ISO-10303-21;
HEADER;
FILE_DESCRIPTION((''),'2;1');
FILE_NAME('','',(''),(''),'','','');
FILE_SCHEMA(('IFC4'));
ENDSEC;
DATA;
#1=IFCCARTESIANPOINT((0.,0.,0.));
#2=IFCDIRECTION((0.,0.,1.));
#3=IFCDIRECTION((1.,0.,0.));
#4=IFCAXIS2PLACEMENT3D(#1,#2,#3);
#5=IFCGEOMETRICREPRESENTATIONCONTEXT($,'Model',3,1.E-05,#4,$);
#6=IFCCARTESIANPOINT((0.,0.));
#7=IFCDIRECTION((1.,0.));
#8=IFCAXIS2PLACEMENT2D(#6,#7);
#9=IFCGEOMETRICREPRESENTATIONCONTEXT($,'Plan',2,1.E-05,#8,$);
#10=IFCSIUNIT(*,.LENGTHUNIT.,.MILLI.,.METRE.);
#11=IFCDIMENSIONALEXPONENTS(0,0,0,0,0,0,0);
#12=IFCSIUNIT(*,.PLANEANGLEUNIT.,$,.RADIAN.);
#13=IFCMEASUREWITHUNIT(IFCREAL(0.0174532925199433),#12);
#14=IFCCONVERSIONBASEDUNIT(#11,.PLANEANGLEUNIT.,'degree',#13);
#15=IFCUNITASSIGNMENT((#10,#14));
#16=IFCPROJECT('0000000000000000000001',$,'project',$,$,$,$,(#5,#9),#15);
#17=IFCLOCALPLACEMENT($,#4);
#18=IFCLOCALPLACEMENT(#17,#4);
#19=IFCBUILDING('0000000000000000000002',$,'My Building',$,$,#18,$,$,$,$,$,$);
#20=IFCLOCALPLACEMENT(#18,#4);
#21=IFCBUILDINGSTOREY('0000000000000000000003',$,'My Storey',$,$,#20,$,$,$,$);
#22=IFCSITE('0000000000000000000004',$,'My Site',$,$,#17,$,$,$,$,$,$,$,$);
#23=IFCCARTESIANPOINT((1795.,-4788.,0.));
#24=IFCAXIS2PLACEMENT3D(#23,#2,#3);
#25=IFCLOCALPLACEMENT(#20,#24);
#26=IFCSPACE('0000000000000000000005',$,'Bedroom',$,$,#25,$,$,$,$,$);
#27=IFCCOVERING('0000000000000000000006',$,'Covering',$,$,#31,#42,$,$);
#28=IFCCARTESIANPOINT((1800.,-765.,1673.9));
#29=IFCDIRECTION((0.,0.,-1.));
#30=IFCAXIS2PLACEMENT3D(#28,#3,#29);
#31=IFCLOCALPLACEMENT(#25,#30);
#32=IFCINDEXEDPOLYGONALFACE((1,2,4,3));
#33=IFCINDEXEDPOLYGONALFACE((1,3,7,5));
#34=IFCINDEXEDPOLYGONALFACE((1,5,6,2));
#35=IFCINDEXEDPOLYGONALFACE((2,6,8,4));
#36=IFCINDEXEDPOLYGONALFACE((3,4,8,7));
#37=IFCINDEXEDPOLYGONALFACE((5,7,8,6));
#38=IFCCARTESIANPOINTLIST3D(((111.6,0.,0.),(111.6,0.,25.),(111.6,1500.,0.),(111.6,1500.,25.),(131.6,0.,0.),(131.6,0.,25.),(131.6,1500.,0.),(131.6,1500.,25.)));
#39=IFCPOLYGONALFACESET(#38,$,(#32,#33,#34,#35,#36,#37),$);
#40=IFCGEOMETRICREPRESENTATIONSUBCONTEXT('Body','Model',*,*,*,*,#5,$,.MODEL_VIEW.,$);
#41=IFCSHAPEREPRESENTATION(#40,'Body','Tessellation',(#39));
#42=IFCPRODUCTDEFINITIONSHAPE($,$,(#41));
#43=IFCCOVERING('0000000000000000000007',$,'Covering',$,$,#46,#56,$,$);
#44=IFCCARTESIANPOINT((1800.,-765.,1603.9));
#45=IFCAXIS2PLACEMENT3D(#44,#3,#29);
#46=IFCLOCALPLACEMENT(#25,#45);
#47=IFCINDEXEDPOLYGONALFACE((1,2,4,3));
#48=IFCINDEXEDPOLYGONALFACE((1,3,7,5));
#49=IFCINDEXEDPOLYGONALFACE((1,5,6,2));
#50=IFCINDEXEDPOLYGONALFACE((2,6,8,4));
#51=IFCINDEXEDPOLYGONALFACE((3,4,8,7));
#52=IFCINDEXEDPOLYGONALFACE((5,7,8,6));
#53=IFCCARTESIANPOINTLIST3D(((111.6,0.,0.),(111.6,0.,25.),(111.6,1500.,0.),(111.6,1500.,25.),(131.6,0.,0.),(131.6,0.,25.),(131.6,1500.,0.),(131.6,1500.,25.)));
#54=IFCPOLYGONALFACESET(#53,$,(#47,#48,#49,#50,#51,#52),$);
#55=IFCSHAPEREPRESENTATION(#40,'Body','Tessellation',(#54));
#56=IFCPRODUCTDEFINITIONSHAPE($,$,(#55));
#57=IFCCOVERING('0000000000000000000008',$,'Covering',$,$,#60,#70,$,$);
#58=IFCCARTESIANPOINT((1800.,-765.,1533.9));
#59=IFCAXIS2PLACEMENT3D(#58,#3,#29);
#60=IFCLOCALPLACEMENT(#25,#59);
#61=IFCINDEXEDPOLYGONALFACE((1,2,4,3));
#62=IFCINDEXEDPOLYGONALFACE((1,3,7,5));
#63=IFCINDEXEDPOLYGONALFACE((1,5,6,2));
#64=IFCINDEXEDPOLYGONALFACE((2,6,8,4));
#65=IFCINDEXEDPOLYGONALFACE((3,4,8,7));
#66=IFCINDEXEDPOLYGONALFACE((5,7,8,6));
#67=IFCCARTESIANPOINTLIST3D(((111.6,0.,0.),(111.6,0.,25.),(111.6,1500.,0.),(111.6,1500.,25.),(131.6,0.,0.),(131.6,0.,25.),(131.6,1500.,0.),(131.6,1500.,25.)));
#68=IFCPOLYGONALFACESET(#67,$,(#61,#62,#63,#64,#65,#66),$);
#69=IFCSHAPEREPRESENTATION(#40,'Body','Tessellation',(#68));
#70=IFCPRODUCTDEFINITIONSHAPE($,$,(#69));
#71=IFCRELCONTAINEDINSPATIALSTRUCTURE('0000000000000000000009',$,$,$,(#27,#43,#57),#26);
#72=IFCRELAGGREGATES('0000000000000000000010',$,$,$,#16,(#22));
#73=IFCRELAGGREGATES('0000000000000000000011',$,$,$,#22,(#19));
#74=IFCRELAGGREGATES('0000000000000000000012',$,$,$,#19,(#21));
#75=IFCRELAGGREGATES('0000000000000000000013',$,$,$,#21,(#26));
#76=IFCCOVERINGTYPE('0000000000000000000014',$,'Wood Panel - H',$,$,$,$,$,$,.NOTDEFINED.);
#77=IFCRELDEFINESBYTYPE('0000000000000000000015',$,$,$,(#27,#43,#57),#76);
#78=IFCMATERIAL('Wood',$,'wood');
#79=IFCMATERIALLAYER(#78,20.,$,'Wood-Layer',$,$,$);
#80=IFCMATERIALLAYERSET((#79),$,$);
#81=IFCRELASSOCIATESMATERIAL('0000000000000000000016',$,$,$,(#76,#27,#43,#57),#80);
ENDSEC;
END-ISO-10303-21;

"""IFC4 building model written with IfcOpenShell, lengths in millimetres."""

from ifc_helpers import new_model, entity, si_unit, converted_unit, frame, origin_with_axes, origin_2d_with_axis, place, context, subcontext, project, spatial, line, indexed_curve, outline, extrude, material, layer, layer_set, layer_usage, type_object, element, save


model = new_model("IFC4")

# Units and contexts
model_context = context("Model", 3, precision=1e-05, world=origin_with_axes())
plan_context = context("Plan", 2, precision=1e-05, world=origin_2d_with_axis())
body_context_1 = subcontext(model_context, "Body", "Model", "MODEL_VIEW")
ifc_project = project(units=[si_unit("LENGTHUNIT", "METRE", prefix="MILLI"), converted_unit("PLANEANGLEUNIT", "degree", entity("IfcReal", 0.0174532925199433), si_unit("PLANEANGLEUNIT", "RADIAN"), dimensions=[0, 0, 0, 0, 0, 0, 0])], contexts=[model_context, plan_context])

# Site, building, storey
site_placement = place(None, origin_with_axes())
site = spatial("IfcSite", under=ifc_project, at=site_placement, Name="My Site")
building_placement = place(site_placement, origin_with_axes())
building = spatial("IfcBuilding", under=site, at=building_placement, Name="My Building")
storey_placement = place(building_placement, origin_with_axes())
storey = spatial("IfcBuildingStorey", under=building, at=storey_placement, Name="My Storey")

# Shared definitions
space_placement = place(storey_placement, frame((1795.0, -4788.0, 0.0), z_axis=(0.0, 0.0, 1.0), x_axis=(1.0, 0.0, 0.0)))
space = spatial("IfcSpace", under=storey, at=space_placement, Name="Bedroom")

# Coverings
ifc_material_1 = material(Name="Wood", Category="wood")
ifc_layer_1 = layer(ifc_material_1, 20.0, Name="Wood-Layer")
ifc_layer_set_1 = layer_set([ifc_layer_1])
covering_type_1 = type_object("IfcCoveringType", Name="Wood Panel - H", PredefinedType="NOTDEFINED", material=ifc_layer_set_1)
ifc_layer_usage_1 = layer_usage(ifc_layer_set_1, "AXIS3", "POSITIVE", 0.0)
covering_1_placement = place(space_placement, frame((1800.0, -765.0, 1673.9), z_axis=(1.0, 0.0, 0.0), x_axis=(0.0, 0.0, -1.0)))
element("IfcCovering", 1, at=covering_1_placement, inside=space, type_object=covering_type_1, material=ifc_layer_usage_1, Name="Covering", context=body_context_1, shape_type="SweptSolid", body=[
    extrude(outline(indexed_curve([(131.6, 1500.0), (111.6, 1500.0), (111.6, 0.0), (131.6, 0.0)], segments=[line(3, 2), line(2, 1), line(1, 4), line(4, 3)], self_intersect=False)), None, (0.0, 0.0, 1.0), 25.0),
])
ifc_layer_usage_2 = layer_usage(ifc_layer_set_1, "AXIS3", "POSITIVE", 0.0)
covering_2_placement = place(space_placement, frame((1800.0, -765.0, 1603.9), z_axis=(1.0, 0.0, 0.0), x_axis=(0.0, 0.0, -1.0)))
element("IfcCovering", 2, at=covering_2_placement, inside=space, type_object=covering_type_1, material=ifc_layer_usage_2, Name="Covering", context=body_context_1, shape_type="SweptSolid", body=[
    extrude(outline(indexed_curve([(131.6, 1500.0), (111.6, 1500.0), (111.6, 0.0), (131.6, 0.0)], segments=[line(3, 2), line(2, 1), line(1, 4), line(4, 3)], self_intersect=False)), None, (0.0, 0.0, 1.0), 25.0),
])
ifc_layer_usage_3 = layer_usage(ifc_layer_set_1, "AXIS3", "POSITIVE", 0.0)
covering_3_placement = place(space_placement, frame((1800.0, -765.0, 1533.9), z_axis=(1.0, 0.0, 0.0), x_axis=(0.0, 0.0, -1.0)))
element("IfcCovering", 3, at=covering_3_placement, inside=space, type_object=covering_type_1, material=ifc_layer_usage_3, Name="Covering", context=body_context_1, shape_type="SweptSolid", body=[
    extrude(outline(indexed_curve([(131.6, 1500.0), (111.6, 1500.0), (111.6, 0.0), (131.6, 0.0)], segments=[line(3, 2), line(2, 1), line(1, 4), line(4, 3)], self_intersect=False)), None, (0.0, 0.0, 1.0), 25.0),
])

save(model, "model.ifc")
